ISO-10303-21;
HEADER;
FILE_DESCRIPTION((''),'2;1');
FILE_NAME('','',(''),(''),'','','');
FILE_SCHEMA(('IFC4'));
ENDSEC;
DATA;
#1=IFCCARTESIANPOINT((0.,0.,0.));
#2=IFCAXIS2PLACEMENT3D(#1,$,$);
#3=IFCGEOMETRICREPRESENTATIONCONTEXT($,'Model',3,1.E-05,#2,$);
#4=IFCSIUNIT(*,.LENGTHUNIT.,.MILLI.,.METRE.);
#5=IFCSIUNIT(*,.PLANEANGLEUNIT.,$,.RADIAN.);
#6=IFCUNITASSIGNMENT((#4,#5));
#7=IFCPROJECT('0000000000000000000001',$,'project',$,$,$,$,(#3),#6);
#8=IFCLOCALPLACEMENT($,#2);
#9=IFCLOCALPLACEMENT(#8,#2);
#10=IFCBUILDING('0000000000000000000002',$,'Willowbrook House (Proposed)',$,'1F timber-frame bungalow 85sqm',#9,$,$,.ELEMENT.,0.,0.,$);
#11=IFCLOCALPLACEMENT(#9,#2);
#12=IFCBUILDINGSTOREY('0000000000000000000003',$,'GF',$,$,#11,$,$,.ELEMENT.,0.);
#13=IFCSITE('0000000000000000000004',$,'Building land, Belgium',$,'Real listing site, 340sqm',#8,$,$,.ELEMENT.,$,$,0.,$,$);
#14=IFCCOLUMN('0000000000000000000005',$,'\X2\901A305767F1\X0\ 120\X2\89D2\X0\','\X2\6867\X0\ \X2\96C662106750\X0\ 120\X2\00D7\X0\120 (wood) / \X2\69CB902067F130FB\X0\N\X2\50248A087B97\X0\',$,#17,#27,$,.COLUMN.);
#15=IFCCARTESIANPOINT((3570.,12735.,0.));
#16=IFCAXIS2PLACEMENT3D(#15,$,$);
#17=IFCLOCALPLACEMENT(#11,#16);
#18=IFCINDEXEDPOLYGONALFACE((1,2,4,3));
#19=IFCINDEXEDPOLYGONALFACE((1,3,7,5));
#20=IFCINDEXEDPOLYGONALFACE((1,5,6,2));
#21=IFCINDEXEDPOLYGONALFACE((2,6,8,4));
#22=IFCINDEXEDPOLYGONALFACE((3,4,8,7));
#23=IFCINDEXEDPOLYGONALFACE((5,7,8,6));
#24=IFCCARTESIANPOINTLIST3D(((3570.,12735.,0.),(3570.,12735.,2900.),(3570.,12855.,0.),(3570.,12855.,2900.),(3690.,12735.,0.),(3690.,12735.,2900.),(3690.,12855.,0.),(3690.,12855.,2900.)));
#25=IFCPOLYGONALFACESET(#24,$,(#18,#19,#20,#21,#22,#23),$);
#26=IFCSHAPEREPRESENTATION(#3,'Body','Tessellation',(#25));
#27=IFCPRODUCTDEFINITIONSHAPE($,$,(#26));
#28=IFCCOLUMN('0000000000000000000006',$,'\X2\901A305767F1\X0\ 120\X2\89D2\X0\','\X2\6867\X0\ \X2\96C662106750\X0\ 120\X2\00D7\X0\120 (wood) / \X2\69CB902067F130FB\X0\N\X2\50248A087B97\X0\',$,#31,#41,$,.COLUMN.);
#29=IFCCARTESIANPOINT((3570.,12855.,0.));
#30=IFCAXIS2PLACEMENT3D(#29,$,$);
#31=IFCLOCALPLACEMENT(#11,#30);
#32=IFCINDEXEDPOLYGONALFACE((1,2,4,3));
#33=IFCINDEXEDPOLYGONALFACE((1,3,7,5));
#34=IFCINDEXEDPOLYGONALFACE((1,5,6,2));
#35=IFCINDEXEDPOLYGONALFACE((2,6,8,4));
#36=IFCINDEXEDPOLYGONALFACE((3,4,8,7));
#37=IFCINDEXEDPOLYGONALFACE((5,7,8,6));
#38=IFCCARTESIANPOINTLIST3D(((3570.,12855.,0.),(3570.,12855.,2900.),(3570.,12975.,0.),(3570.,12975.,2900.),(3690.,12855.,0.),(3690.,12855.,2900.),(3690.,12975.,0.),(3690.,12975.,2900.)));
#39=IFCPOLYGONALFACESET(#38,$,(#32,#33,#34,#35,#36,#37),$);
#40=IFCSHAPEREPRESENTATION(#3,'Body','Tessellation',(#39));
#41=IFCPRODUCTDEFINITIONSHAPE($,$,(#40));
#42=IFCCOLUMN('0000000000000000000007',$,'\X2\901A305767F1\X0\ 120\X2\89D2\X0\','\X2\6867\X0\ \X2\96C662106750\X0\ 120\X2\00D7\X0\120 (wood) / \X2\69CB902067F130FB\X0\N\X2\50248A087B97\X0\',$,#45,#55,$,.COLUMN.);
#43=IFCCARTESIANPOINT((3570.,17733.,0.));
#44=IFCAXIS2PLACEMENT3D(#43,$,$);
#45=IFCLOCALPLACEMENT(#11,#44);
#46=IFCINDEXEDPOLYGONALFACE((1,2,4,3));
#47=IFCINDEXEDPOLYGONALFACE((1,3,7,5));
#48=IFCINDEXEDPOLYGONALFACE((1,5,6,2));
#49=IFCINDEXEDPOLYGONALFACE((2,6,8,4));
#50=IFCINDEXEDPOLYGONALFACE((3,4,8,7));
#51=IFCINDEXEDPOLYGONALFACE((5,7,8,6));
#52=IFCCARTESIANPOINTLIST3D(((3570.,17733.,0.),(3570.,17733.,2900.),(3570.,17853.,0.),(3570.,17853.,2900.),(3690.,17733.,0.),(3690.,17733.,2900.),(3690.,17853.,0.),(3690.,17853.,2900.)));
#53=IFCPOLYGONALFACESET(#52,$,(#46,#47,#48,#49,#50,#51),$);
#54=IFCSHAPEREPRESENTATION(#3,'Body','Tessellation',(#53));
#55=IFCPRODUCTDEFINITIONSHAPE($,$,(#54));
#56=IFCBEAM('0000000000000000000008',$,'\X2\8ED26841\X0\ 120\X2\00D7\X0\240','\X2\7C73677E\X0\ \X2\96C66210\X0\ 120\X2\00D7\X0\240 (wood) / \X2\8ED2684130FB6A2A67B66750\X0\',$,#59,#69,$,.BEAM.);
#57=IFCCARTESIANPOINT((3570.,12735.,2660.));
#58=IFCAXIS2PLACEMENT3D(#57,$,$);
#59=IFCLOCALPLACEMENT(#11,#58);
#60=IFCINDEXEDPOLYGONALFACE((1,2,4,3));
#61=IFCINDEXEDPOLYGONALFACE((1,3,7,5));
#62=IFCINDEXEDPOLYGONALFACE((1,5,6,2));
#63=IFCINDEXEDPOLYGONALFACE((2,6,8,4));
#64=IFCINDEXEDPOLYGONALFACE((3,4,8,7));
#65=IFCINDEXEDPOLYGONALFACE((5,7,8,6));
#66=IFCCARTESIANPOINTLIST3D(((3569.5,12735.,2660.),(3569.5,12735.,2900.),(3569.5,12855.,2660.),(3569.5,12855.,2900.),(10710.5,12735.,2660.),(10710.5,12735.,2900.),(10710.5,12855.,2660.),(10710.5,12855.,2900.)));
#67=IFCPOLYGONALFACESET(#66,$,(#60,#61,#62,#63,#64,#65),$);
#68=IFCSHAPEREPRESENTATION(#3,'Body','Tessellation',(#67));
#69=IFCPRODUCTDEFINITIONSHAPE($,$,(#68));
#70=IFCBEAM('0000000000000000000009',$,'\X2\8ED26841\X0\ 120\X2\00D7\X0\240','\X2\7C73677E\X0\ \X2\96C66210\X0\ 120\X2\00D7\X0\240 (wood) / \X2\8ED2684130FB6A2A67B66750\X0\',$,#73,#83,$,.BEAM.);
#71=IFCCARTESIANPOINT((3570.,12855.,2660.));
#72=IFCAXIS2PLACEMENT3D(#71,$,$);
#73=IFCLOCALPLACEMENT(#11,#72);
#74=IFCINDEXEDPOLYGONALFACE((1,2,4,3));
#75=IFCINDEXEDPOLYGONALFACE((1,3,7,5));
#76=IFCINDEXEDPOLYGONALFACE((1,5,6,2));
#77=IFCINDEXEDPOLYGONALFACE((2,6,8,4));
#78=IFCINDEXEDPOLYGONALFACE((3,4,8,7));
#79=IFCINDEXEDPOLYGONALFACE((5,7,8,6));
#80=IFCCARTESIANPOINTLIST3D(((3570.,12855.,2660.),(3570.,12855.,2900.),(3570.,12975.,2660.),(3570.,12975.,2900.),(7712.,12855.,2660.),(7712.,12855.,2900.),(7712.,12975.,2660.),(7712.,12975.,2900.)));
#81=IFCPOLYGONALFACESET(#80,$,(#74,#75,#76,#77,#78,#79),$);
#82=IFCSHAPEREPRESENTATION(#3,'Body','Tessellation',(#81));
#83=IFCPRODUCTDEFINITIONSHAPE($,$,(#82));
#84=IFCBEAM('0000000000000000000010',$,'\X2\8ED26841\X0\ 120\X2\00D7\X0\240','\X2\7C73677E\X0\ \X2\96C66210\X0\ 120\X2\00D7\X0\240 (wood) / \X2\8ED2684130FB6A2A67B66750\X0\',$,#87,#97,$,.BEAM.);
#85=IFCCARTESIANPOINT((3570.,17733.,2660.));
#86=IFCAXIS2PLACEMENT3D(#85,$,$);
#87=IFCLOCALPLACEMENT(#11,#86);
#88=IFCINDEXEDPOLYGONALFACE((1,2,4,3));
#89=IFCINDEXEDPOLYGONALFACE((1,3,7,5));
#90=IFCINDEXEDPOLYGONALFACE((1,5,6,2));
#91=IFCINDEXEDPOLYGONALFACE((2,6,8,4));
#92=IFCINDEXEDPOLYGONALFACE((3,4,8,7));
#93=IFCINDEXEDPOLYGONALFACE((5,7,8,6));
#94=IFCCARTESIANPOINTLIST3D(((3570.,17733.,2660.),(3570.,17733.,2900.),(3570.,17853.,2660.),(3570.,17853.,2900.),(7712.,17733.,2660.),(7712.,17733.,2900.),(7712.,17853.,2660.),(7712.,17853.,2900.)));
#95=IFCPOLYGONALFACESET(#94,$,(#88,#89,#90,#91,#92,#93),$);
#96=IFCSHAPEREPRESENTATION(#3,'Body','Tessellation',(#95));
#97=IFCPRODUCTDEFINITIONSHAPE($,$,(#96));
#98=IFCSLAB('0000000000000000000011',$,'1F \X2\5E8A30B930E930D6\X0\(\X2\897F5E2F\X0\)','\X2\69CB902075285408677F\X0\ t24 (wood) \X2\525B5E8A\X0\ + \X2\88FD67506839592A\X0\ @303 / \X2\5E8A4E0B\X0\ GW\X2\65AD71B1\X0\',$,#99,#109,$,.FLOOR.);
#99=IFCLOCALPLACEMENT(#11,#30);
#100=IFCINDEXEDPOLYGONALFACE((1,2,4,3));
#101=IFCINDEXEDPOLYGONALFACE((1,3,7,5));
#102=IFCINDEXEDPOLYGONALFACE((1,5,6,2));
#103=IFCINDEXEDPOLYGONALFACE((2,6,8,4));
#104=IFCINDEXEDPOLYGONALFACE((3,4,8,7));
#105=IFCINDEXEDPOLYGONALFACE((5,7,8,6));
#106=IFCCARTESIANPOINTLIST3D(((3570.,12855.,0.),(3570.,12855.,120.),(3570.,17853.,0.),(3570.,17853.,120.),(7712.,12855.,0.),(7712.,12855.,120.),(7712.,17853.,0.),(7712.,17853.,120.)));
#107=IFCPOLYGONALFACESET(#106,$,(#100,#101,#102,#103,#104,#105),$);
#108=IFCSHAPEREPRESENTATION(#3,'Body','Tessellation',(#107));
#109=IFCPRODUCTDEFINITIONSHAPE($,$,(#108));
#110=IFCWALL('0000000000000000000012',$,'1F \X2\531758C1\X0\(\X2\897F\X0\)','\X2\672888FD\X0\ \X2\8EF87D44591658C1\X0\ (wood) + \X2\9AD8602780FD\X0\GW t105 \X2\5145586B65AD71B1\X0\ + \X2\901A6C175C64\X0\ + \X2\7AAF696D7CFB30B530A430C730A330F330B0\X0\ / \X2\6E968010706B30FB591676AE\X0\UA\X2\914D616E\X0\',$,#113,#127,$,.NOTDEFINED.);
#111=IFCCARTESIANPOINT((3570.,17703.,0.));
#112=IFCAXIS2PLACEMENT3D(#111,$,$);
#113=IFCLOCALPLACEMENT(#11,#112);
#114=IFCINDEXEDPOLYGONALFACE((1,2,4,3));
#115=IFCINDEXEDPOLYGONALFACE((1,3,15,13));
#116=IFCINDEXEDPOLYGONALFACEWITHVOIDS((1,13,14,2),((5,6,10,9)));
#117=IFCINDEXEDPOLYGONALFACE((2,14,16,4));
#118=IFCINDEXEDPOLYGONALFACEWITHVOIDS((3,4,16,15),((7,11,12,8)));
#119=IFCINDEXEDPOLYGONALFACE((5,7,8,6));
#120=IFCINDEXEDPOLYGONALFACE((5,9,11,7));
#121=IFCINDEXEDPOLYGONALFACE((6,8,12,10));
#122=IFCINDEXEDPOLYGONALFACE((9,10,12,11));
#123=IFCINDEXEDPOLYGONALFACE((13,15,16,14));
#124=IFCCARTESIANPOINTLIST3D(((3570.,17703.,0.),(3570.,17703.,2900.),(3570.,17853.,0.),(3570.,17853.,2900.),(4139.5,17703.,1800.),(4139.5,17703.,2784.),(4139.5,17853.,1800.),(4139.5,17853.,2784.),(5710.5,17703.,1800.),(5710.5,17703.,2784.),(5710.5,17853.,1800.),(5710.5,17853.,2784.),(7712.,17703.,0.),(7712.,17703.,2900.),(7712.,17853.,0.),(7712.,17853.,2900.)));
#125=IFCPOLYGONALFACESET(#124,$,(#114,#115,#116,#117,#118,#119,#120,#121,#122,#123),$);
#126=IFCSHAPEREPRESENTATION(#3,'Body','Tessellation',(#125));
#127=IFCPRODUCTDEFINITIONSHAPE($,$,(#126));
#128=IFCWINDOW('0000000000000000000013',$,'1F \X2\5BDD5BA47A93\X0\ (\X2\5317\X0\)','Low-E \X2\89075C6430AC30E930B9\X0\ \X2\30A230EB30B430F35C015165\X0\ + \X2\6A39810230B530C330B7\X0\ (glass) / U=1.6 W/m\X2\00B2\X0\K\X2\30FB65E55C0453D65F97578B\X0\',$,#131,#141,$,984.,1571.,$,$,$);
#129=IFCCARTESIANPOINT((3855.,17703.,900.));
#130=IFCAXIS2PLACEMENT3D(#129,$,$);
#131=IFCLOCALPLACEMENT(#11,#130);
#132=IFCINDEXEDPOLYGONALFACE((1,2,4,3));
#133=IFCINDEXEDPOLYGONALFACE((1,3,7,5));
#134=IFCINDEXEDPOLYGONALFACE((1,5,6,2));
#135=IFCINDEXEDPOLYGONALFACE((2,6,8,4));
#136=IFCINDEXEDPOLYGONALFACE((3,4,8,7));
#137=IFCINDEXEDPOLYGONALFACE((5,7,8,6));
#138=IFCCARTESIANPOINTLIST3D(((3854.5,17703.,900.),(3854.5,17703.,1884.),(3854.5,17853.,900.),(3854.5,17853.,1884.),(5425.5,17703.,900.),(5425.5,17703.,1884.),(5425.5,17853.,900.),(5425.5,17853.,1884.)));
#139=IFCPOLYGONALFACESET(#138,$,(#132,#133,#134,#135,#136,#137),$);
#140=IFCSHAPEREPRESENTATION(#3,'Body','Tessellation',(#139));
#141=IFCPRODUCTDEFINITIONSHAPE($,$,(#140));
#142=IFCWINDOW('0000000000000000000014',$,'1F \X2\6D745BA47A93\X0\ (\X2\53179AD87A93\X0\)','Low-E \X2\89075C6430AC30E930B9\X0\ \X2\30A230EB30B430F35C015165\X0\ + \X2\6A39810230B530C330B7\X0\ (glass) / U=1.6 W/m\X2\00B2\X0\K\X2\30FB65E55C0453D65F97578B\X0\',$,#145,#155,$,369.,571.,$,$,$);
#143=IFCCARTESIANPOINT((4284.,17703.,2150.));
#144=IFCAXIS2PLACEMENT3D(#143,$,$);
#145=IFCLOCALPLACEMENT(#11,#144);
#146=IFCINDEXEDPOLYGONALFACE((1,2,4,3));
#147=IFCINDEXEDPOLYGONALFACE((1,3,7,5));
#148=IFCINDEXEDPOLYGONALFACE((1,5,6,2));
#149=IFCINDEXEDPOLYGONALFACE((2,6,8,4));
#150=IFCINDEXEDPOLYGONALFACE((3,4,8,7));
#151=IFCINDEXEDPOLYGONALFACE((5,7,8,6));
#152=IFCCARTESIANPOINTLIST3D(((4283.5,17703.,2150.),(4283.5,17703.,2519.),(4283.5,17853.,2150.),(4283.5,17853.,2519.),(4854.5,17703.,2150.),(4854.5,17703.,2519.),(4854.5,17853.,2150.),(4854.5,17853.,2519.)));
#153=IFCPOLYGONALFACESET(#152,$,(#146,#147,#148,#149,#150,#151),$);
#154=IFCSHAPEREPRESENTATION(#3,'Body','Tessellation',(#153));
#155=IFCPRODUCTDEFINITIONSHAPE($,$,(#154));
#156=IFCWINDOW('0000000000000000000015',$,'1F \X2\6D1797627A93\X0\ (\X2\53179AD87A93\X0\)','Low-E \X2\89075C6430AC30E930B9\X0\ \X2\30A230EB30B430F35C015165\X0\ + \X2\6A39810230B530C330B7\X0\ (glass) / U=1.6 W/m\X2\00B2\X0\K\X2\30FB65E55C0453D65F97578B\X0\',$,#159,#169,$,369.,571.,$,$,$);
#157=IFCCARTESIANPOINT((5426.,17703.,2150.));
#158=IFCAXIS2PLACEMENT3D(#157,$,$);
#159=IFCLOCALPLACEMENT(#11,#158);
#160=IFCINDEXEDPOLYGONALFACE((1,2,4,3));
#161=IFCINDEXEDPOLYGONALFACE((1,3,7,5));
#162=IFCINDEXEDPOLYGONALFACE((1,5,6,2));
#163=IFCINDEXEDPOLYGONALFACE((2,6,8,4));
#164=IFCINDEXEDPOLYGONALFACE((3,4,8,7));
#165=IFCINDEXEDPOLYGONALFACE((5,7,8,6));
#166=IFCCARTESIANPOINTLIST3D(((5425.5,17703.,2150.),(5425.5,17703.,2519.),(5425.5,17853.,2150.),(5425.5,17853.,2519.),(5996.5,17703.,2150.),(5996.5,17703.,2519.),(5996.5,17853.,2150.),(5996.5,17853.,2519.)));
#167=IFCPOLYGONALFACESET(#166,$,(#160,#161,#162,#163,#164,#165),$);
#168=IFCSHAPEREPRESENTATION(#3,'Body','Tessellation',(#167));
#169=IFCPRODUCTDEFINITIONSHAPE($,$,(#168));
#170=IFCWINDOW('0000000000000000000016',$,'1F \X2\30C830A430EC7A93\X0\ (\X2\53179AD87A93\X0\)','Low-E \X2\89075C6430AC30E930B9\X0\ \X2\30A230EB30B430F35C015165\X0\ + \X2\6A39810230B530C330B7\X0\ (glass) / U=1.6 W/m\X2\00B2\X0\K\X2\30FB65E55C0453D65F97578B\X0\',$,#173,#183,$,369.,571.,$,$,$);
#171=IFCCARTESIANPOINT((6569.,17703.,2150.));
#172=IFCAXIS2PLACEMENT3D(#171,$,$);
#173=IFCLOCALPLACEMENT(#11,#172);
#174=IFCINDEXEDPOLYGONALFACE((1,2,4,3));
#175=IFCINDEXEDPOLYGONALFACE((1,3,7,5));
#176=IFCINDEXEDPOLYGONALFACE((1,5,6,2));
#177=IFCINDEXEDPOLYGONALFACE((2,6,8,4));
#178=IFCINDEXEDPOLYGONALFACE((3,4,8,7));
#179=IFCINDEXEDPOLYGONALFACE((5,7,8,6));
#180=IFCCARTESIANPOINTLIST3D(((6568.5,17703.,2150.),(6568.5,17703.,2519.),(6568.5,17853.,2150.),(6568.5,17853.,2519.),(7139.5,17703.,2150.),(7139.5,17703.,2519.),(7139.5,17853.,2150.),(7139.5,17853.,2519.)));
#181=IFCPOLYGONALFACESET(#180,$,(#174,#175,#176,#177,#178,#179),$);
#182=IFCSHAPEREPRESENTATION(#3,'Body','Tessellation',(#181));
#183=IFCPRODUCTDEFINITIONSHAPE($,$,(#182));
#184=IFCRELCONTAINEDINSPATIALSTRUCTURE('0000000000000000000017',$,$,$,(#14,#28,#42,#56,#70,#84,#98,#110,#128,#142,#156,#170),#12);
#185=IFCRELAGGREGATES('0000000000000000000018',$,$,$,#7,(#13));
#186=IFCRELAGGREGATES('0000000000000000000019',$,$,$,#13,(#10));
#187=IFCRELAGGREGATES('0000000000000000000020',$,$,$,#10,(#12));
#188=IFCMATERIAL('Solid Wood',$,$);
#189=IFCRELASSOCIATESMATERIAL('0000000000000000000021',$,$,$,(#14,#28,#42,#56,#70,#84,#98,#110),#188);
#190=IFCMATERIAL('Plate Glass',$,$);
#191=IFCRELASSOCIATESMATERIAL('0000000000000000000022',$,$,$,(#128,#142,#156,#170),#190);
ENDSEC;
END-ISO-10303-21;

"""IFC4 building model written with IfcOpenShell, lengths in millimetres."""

from ifc_helpers import new_model, si_unit, frame, frame_2d, origin, place, context, project, spatial, rectangle, extrude, material, element, fill, save


model = new_model("IFC4")

# Units and contexts
model_context = context("Model", 3, precision=1e-05, world=origin())
ifc_project = project(units=[si_unit("LENGTHUNIT", "METRE", prefix="MILLI"), si_unit("PLANEANGLEUNIT", "RADIAN")], contexts=[model_context])

# Site, building, storey
site_placement = place(None, origin())
site = spatial("IfcSite", under=ifc_project, at=site_placement, Name="Building land, Belgium", ObjectType="Real listing site, 340sqm", CompositionType="ELEMENT", RefElevation=0.0)
building_placement = place(site_placement, origin())
building = spatial("IfcBuilding", under=site, at=building_placement, Name="Willowbrook House (Proposed)", ObjectType="1F timber-frame bungalow 85sqm", CompositionType="ELEMENT", ElevationOfRefHeight=0.0, ElevationOfTerrain=0.0)
storey_placement = place(building_placement, origin())
storey = spatial("IfcBuildingStorey", under=building, at=storey_placement, Name="GF", CompositionType="ELEMENT", Elevation=0.0)

# Columns
ifc_material_1 = material(Name="Solid Wood")
column_1_placement = place(storey_placement, frame((3570.0, 12735.0, 0.0)))
element("IfcColumn", 1, at=column_1_placement, inside=storey, material=ifc_material_1, Name="通し柱 120角", Description="桧 集成材 120×120 (wood) / 構造柱・N値計算", PredefinedType="COLUMN", context=model_context, shape_type="SweptSolid", body=[
    extrude(rectangle(XDim=120.0, YDim=120.0, at=frame_2d((60.0, 60.0))), frame((3570.0, 12735.0, 0.0)), (0.0, 0.0, 1.0), 2900.0),
])
column_2_placement = place(storey_placement, frame((3570.0, 12855.0, 0.0)))
element("IfcColumn", 2, at=column_2_placement, inside=storey, material=ifc_material_1, Name="通し柱 120角", Description="桧 集成材 120×120 (wood) / 構造柱・N値計算", PredefinedType="COLUMN", context=model_context, shape_type="SweptSolid", body=[
    extrude(rectangle(XDim=120.0, YDim=120.0, at=frame_2d((60.0, 60.0))), frame((3570.0, 12855.0, 0.0)), (0.0, 0.0, 1.0), 2900.0),
])
column_3_placement = place(storey_placement, frame((3570.0, 17733.0, 0.0)))
element("IfcColumn", 3, at=column_3_placement, inside=storey, material=ifc_material_1, Name="通し柱 120角", Description="桧 集成材 120×120 (wood) / 構造柱・N値計算", PredefinedType="COLUMN", context=model_context, shape_type="SweptSolid", body=[
    extrude(rectangle(XDim=120.0, YDim=120.0, at=frame_2d((60.0, 60.0))), frame((3570.0, 17733.0, 0.0)), (0.0, 0.0, 1.0), 2900.0),
])

# Beams
beam_1_placement = place(storey_placement, frame((3570.0, 12735.0, 2660.0)))
element("IfcBeam", 4, at=beam_1_placement, inside=storey, material=ifc_material_1, Name="軒桁 120×240", Description="米松 集成 120×240 (wood) / 軒桁・横架材", PredefinedType="BEAM", context=model_context, shape_type="SweptSolid", body=[
    extrude(rectangle(XDim=7141.0, YDim=120.0, at=frame_2d((3570.0, 60.0))), frame((3570.0, 12735.0, 2660.0)), (0.0, 0.0, 1.0), 240.0),
])
beam_2_placement = place(storey_placement, frame((3570.0, 12855.0, 2660.0)))
element("IfcBeam", 5, at=beam_2_placement, inside=storey, material=ifc_material_1, Name="軒桁 120×240", Description="米松 集成 120×240 (wood) / 軒桁・横架材", PredefinedType="BEAM", context=model_context, shape_type="SweptSolid", body=[
    extrude(rectangle(XDim=4142.0, YDim=120.0, at=frame_2d((2071.0, 60.0))), frame((3570.0, 12855.0, 2660.0)), (0.0, 0.0, 1.0), 240.0),
])
beam_3_placement = place(storey_placement, frame((3570.0, 17733.0, 2660.0)))
element("IfcBeam", 6, at=beam_3_placement, inside=storey, material=ifc_material_1, Name="軒桁 120×240", Description="米松 集成 120×240 (wood) / 軒桁・横架材", PredefinedType="BEAM", context=model_context, shape_type="SweptSolid", body=[
    extrude(rectangle(XDim=4142.0, YDim=120.0, at=frame_2d((2071.0, 60.0))), frame((3570.0, 17733.0, 2660.0)), (0.0, 0.0, 1.0), 240.0),
])

# Slab
slab_placement = place(storey_placement, frame((3570.0, 12855.0, 0.0)))
element("IfcSlab", 7, at=slab_placement, inside=storey, material=ifc_material_1, Name="1F 床スラブ(西帯)", Description="構造用合板 t24 (wood) 剛床 + 製材根太 @303 / 床下 GW断熱", PredefinedType="FLOOR", context=model_context, shape_type="SweptSolid", body=[
    extrude(rectangle(XDim=4142.0, YDim=4998.0, at=frame_2d((2071.0, 2499.0))), frame((3570.0, 12855.0, 0.0)), (0.0, 0.0, 1.0), 120.0),
])

# Wall, openings, windows
wall_1_placement = place(storey_placement, frame((3570.0, 17703.0, 0.0)))
wall_1 = element("IfcWall", 8, at=wall_1_placement, inside=storey, material=ifc_material_1, Name="1F 北壁(西)", Description="木製 軸組外壁 (wood) + 高性能GW t105 充填断熱 + 通気層 + 窯業系サイディング / 準耐火・外皮UA配慮", PredefinedType="NOTDEFINED", context=model_context, shape_type="SweptSolid", body=[
    extrude(rectangle(XDim=4142.0, YDim=150.0, at=frame_2d((2071.0, 75.0))), frame((3570.0, 17703.0, 0.0)), (0.0, 0.0, 1.0), 2900.0),
])
opening_1_placement = place(storey_placement, frame((3855.0, 17703.0, 900.0)))
opening_1 = element("IfcOpeningElement", 9, at=opening_1_placement, cuts=wall_1, PredefinedType="NOTDEFINED", context=model_context, shape_type="SweptSolid", body=[
    extrude(rectangle(XDim=1571.0, YDim=150.0, at=frame_2d((785.0, 75.0))), frame((3855.0, 17703.0, 900.0)), (0.0, 0.0, 1.0), 984.0),
])
opening_2_placement = place(storey_placement, frame((4284.0, 17703.0, 2150.0)))
opening_2 = element("IfcOpeningElement", 10, at=opening_2_placement, cuts=wall_1, PredefinedType="NOTDEFINED", context=model_context, shape_type="SweptSolid", body=[
    extrude(rectangle(XDim=571.0, YDim=150.0, at=frame_2d((285.0, 75.0))), frame((4284.0, 17703.0, 2150.0)), (0.0, 0.0, 1.0), 369.0),
])
opening_3_placement = place(storey_placement, frame((5426.0, 17703.0, 2150.0)))
opening_3 = element("IfcOpeningElement", 11, at=opening_3_placement, cuts=wall_1, PredefinedType="NOTDEFINED", context=model_context, shape_type="SweptSolid", body=[
    extrude(rectangle(XDim=571.0, YDim=150.0, at=frame_2d((285.0, 75.0))), frame((5426.0, 17703.0, 2150.0)), (0.0, 0.0, 1.0), 369.0),
])
opening_4_placement = place(storey_placement, frame((6569.0, 17703.0, 2150.0)))
opening_4 = element("IfcOpeningElement", 12, at=opening_4_placement, cuts=wall_1, PredefinedType="NOTDEFINED", context=model_context, shape_type="SweptSolid", body=[
    extrude(rectangle(XDim=571.0, YDim=150.0, at=frame_2d((285.0, 75.0))), frame((6569.0, 17703.0, 2150.0)), (0.0, 0.0, 1.0), 369.0),
])
ifc_material_2 = material(Name="Plate Glass")
window_1_placement = place(storey_placement, frame((3855.0, 17703.0, 900.0)))
window_1 = element("IfcWindow", 13, at=window_1_placement, inside=storey, material=ifc_material_2, Name="1F 寝室窓 (北)", Description="Low-E 複層ガラス アルゴン封入 + 樹脂サッシ (glass) / U=1.6 W/m²K・日射取得型", OverallHeight=984.0, OverallWidth=1571.0, context=model_context, shape_type="SweptSolid", body=[
    extrude(rectangle(XDim=1571.0, YDim=150.0, at=frame_2d((785.0, 75.0))), frame((3855.0, 17703.0, 900.0)), (0.0, 0.0, 1.0), 984.0),
])
fill(opening_1, window_1)
window_2_placement = place(storey_placement, frame((4284.0, 17703.0, 2150.0)))
window_2 = element("IfcWindow", 14, at=window_2_placement, inside=storey, material=ifc_material_2, Name="1F 浴室窓 (北高窓)", Description="Low-E 複層ガラス アルゴン封入 + 樹脂サッシ (glass) / U=1.6 W/m²K・日射取得型", OverallHeight=369.0, OverallWidth=571.0, context=model_context, shape_type="SweptSolid", body=[
    extrude(rectangle(XDim=571.0, YDim=150.0, at=frame_2d((285.0, 75.0))), frame((4284.0, 17703.0, 2150.0)), (0.0, 0.0, 1.0), 369.0),
])
fill(opening_2, window_2)
window_3_placement = place(storey_placement, frame((5426.0, 17703.0, 2150.0)))
window_3 = element("IfcWindow", 15, at=window_3_placement, inside=storey, material=ifc_material_2, Name="1F 洗面窓 (北高窓)", Description="Low-E 複層ガラス アルゴン封入 + 樹脂サッシ (glass) / U=1.6 W/m²K・日射取得型", OverallHeight=369.0, OverallWidth=571.0, context=model_context, shape_type="SweptSolid", body=[
    extrude(rectangle(XDim=571.0, YDim=150.0, at=frame_2d((285.0, 75.0))), frame((5426.0, 17703.0, 2150.0)), (0.0, 0.0, 1.0), 369.0),
])
fill(opening_3, window_3)
window_4_placement = place(storey_placement, frame((6569.0, 17703.0, 2150.0)))
window_4 = element("IfcWindow", 16, at=window_4_placement, inside=storey, material=ifc_material_2, Name="1F トイレ窓 (北高窓)", Description="Low-E 複層ガラス アルゴン封入 + 樹脂サッシ (glass) / U=1.6 W/m²K・日射取得型", OverallHeight=369.0, OverallWidth=571.0, context=model_context, shape_type="SweptSolid", body=[
    extrude(rectangle(XDim=571.0, YDim=150.0, at=frame_2d((285.0, 75.0))), frame((6569.0, 17703.0, 2150.0)), (0.0, 0.0, 1.0), 369.0),
])
fill(opening_4, window_4)

save(model, "model.ifc")
